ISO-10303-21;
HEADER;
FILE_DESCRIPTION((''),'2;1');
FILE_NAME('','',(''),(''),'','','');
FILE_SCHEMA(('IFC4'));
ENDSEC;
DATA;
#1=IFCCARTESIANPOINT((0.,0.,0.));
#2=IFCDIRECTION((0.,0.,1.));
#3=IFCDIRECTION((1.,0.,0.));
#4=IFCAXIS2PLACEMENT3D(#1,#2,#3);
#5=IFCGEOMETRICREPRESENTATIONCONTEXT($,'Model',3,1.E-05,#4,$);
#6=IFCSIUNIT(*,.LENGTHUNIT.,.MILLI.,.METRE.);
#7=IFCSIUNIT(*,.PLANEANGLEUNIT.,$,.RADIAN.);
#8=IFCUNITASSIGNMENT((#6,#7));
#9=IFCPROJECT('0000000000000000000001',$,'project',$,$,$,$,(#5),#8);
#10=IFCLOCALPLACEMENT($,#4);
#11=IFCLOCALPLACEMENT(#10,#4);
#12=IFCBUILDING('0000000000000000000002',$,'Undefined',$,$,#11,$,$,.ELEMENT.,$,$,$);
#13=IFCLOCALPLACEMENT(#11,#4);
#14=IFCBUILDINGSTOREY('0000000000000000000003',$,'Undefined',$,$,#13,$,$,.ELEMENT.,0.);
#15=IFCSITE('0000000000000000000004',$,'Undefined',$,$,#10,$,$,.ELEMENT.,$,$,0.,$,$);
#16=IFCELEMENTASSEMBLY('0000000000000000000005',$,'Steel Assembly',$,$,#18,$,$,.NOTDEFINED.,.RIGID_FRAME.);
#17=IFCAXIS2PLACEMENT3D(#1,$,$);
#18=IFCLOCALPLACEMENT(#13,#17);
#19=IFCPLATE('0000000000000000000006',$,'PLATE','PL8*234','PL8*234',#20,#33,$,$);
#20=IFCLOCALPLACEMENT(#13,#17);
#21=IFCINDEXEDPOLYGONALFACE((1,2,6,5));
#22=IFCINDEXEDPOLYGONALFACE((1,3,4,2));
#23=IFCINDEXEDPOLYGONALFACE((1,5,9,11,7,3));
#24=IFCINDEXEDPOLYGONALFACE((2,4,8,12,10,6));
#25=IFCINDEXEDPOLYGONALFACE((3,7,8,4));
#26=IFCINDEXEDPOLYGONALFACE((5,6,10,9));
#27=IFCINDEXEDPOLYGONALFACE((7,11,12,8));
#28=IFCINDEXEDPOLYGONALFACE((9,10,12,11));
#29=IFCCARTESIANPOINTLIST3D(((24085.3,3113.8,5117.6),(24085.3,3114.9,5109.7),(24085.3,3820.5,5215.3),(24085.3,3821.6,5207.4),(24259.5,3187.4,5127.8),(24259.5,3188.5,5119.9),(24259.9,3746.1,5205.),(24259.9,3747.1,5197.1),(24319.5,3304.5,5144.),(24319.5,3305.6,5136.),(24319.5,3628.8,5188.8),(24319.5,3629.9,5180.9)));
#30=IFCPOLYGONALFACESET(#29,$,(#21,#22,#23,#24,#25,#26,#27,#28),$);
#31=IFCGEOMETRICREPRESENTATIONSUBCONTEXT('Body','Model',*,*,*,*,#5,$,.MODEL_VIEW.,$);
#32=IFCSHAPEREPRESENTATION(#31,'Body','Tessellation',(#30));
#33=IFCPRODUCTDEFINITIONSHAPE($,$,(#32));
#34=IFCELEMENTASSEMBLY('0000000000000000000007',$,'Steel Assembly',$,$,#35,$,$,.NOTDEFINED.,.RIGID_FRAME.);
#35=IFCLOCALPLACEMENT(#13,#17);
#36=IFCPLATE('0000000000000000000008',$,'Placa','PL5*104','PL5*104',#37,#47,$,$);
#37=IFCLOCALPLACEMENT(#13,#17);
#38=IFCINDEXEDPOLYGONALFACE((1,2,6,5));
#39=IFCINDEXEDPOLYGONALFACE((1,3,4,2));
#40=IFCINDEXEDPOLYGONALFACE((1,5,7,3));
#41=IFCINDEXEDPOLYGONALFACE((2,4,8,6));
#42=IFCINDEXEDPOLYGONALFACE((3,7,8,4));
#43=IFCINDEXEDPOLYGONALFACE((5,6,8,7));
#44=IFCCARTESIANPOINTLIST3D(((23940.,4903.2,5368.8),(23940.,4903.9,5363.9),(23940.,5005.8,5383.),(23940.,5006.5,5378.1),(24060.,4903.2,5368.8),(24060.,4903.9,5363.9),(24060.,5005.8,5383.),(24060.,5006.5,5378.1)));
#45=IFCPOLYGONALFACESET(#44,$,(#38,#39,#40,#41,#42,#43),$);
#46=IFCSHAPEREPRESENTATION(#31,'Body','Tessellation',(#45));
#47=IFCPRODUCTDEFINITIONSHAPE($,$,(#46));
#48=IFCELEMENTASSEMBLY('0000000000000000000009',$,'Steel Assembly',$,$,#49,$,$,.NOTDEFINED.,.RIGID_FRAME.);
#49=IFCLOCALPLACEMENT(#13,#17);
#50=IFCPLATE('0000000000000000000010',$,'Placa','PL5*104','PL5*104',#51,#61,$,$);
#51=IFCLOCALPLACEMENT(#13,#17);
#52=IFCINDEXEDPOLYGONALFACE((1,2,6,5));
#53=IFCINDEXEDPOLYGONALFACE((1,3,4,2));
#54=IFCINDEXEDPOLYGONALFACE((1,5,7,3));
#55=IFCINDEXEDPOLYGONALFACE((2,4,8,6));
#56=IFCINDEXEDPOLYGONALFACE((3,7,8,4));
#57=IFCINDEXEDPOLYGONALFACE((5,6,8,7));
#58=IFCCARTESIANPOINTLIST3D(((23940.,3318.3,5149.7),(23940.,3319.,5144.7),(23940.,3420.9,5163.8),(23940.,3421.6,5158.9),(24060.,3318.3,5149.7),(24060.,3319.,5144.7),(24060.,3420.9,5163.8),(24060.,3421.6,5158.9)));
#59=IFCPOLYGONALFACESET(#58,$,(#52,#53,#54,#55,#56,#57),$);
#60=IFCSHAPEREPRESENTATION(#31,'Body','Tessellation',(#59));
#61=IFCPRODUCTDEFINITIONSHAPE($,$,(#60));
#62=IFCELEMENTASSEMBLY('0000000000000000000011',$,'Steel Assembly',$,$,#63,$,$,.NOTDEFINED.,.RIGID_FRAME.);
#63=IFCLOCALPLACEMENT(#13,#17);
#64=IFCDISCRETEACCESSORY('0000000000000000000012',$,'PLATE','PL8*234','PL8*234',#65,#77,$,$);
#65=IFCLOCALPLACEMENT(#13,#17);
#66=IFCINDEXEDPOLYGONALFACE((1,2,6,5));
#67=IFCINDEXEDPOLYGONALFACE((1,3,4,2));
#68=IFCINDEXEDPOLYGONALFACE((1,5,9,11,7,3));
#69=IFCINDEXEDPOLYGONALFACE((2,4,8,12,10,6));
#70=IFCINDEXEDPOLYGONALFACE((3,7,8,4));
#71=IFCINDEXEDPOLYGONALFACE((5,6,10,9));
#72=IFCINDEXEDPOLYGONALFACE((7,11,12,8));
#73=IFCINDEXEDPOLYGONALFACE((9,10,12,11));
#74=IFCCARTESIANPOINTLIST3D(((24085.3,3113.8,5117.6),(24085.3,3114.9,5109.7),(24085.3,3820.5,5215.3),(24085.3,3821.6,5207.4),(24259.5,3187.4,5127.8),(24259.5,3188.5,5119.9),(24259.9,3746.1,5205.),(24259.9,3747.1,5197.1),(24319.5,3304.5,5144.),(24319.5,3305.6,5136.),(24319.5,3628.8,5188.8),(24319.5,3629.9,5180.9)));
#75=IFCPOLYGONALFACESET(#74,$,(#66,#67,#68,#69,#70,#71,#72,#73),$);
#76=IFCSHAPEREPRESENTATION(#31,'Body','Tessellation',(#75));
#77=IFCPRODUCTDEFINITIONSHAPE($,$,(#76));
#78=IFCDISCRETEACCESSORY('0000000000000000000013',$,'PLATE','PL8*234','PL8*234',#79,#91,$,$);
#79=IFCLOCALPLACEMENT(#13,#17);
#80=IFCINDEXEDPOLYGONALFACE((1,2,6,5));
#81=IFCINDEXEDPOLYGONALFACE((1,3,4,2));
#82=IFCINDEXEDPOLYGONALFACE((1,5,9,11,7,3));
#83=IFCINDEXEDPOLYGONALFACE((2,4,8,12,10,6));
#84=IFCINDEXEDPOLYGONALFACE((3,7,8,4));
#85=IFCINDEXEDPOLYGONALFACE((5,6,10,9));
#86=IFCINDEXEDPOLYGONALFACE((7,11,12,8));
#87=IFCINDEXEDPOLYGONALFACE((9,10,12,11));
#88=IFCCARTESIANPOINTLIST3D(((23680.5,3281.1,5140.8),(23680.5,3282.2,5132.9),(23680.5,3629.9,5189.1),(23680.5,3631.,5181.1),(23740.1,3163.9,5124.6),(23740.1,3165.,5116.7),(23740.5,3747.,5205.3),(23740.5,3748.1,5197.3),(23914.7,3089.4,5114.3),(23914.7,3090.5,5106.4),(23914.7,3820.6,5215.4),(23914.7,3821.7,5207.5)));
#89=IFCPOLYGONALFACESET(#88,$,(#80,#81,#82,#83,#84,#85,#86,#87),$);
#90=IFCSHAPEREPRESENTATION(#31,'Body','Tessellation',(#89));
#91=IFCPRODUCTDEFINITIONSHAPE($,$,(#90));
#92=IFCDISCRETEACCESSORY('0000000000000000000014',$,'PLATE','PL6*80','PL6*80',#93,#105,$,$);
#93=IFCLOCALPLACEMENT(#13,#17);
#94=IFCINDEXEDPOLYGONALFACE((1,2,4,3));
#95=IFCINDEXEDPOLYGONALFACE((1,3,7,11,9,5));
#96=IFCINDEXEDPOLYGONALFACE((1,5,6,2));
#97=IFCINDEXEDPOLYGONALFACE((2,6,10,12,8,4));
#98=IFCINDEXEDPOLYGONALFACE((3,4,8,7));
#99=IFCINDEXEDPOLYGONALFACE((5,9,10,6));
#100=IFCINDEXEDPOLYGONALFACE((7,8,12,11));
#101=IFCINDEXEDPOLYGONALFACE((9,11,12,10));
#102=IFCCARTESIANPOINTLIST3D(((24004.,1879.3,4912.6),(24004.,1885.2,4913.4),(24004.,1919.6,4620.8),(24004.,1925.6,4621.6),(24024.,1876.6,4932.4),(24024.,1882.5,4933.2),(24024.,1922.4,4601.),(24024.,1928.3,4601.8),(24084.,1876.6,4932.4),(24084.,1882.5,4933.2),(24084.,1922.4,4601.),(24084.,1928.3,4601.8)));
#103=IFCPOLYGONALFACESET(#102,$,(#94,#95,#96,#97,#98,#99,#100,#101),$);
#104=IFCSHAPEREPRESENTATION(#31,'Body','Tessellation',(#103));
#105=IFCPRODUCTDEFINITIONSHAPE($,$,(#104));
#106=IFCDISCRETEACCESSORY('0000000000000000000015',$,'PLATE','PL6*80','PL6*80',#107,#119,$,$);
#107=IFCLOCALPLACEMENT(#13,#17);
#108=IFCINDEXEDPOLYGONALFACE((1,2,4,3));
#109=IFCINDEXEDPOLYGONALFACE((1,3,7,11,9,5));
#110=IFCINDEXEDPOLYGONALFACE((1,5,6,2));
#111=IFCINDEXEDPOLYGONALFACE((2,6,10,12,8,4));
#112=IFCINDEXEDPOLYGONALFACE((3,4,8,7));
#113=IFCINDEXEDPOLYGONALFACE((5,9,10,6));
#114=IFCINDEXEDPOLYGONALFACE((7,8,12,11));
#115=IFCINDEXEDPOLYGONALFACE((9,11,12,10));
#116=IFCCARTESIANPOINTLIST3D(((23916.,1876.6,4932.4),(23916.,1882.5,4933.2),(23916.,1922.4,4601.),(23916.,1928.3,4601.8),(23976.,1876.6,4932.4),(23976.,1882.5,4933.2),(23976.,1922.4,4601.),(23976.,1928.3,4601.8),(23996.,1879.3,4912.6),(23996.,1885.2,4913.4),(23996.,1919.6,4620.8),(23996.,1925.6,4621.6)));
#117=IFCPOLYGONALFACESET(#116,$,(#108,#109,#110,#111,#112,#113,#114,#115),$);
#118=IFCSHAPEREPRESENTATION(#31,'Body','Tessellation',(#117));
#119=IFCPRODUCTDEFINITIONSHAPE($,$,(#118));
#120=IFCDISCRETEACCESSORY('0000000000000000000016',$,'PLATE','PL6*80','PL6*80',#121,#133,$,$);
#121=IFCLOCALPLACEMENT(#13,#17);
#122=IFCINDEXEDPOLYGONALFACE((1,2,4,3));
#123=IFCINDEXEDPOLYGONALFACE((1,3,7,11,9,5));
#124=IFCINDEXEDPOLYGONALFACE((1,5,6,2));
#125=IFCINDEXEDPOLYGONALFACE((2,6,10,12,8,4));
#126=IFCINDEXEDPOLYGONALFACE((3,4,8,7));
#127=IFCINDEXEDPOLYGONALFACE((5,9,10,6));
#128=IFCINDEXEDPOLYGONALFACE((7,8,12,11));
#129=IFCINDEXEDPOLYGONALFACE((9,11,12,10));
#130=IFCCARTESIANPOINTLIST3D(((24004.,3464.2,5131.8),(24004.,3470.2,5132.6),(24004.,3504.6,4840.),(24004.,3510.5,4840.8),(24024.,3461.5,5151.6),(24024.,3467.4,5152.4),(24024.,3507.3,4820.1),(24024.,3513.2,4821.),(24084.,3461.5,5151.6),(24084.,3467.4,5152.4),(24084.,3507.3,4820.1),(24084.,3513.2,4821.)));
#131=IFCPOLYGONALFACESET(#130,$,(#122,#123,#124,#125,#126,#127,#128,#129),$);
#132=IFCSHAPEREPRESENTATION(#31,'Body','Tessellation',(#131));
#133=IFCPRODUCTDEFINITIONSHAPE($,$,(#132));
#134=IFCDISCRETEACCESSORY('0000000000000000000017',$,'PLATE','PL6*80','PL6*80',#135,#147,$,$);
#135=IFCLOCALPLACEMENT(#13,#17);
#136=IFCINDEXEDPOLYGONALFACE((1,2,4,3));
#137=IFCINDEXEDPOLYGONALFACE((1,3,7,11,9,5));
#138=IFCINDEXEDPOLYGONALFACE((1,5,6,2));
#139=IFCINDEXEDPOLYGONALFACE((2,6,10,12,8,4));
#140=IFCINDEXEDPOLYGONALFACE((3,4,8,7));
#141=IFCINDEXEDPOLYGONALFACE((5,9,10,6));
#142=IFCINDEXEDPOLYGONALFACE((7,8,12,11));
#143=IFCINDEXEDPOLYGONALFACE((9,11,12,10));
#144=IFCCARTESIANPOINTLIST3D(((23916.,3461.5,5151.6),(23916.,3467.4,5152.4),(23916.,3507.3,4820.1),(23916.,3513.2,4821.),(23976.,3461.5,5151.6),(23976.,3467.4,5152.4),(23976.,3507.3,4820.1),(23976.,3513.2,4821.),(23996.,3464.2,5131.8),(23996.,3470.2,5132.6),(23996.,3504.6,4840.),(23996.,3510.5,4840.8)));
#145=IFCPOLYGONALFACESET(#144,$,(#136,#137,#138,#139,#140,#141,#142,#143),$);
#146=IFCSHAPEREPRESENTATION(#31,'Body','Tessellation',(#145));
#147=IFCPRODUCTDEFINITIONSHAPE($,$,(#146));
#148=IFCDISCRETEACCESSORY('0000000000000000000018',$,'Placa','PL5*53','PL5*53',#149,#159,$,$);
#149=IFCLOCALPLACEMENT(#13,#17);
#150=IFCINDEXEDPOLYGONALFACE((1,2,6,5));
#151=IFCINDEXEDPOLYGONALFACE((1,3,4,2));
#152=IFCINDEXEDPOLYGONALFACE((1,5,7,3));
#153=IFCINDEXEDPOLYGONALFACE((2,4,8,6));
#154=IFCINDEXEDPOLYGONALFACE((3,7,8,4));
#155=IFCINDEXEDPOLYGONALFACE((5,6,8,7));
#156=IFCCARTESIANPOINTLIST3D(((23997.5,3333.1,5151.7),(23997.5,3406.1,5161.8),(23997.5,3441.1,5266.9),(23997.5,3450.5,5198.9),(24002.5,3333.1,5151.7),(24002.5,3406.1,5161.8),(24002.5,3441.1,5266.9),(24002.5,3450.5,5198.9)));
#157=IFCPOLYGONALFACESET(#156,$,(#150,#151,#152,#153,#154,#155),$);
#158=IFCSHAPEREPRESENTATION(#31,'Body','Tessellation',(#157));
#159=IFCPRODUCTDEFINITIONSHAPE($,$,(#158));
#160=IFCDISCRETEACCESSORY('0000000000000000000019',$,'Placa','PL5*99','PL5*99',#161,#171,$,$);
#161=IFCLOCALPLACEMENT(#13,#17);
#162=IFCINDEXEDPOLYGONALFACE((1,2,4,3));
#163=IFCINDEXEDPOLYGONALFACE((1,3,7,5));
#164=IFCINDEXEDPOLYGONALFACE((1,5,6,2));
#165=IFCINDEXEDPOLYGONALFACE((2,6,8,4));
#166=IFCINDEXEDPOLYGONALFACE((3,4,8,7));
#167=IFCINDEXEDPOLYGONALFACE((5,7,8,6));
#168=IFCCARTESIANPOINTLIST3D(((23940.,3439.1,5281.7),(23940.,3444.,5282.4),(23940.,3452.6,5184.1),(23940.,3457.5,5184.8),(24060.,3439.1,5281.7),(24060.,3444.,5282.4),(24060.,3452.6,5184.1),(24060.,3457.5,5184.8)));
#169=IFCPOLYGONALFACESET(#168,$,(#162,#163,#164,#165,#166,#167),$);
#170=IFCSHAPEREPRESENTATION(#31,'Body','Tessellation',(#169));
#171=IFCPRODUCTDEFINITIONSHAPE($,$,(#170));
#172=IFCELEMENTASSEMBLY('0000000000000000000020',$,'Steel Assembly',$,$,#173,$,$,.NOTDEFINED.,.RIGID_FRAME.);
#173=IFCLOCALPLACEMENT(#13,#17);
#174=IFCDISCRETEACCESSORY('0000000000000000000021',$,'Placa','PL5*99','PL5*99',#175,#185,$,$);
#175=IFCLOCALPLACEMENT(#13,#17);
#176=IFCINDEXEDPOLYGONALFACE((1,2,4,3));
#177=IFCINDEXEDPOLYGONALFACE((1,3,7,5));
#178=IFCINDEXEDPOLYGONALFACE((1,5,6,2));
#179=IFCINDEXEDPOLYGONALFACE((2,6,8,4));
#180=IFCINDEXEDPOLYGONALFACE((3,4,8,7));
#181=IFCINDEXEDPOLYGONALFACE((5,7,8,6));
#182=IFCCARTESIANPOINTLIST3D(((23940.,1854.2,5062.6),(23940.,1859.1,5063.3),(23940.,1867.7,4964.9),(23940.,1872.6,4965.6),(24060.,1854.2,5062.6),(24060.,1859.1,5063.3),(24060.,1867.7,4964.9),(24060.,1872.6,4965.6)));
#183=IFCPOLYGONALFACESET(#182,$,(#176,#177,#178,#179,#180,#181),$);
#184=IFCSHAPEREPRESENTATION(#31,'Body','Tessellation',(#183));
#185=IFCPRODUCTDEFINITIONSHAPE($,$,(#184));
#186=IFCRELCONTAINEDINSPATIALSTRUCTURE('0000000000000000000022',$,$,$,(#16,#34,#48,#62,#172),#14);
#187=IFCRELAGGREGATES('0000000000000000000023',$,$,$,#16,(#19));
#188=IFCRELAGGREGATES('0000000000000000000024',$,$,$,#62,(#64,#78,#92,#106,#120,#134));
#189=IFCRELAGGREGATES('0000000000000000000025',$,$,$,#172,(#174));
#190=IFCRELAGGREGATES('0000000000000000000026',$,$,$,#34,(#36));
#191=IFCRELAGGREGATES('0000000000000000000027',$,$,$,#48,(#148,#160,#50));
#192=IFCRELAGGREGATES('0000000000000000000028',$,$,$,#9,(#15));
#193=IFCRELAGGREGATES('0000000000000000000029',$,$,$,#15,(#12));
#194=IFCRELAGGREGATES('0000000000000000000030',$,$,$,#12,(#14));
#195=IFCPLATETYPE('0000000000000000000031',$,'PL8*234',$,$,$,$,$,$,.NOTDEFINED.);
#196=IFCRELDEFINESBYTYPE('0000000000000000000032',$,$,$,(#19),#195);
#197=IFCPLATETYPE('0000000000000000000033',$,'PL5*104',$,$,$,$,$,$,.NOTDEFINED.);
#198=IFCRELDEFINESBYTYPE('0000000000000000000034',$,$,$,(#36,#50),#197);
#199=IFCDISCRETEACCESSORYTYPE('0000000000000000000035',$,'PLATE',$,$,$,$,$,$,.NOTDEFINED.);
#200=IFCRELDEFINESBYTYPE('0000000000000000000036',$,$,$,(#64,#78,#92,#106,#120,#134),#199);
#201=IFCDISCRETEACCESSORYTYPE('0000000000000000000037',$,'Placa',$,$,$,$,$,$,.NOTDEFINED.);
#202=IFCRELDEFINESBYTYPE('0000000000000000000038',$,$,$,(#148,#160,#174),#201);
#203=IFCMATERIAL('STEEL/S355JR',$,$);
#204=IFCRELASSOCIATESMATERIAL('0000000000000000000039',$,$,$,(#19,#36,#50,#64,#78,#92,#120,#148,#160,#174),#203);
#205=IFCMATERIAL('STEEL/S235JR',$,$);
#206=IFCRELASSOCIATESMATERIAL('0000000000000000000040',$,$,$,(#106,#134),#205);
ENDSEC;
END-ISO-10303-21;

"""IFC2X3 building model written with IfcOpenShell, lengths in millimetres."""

from ifc_helpers import new_model, si_unit, frame, origin_with_axes, place, context, subcontext, project, spatial, polyline, outline, extrude, material, type_object, element, aggregate, save


model = new_model("IFC2X3")

# Units and contexts
model_context = context("Model", 3, precision=1e-05, world=origin_with_axes())
body_context = subcontext(model_context, "Body", "Model", "MODEL_VIEW")
ifc_project = project(units=[si_unit("LENGTHUNIT", "METRE", prefix="MILLI"), si_unit("PLANEANGLEUNIT", "RADIAN")], contexts=[model_context])

# Site, building, storey
site_placement = place(None, origin_with_axes())
site = spatial("IfcSite", under=ifc_project, at=site_placement, Name="Undefined", CompositionType="ELEMENT", RefElevation=0.0)
building_placement = place(site_placement, origin_with_axes())
building = spatial("IfcBuilding", under=site, at=building_placement, Name="Undefined", CompositionType="ELEMENT")
storey_placement = place(building_placement, origin_with_axes())
storey = spatial("IfcBuildingStorey", under=building, at=storey_placement, Name="Undefined", CompositionType="ELEMENT", Elevation=0.0)

# Shared definitions
ifc_material_1 = material(Name="STEEL/S355JR")

# Element assemblies, plates
assembly_1_placement = place(storey_placement, origin_with_axes())
assembly_1 = element("IfcElementAssembly", 1, at=assembly_1_placement, inside=storey, Name="Steel Assembly", AssemblyPlace="NOTDEFINED", PredefinedType="RIGID_FRAME")
plate_type_1 = type_object("IfcPlateType", Name="PL8*234", PredefinedType="NOTDEFINED")
plate_1_placement = place(assembly_1_placement, frame((24085.3, 3821.1, 5211.4), z_axis=(-0.000018, -0.13698, 0.990574), x_axis=(0.0, -0.990574, -0.13698)))
plate_1 = element("IfcPlate", 2, at=plate_1_placement, type_object=plate_type_1, material=ifc_material_1, Name="PLATE", Description="PL8*234", ObjectType="PL8*234", context=body_context, shape_type="SweptSolid", body=[
    extrude(outline(polyline([(0.0, 0.0), (713.5, 0.0), (639.1, 174.2), (520.9, 234.3), (193.6, 234.3), (75.2, 174.6), (0.0, 0.0)])), frame((0.0, 0.0, -4.0), z_axis=(0.0, 0.0, 1.0), x_axis=(1.0, 0.0, 0.0)), (0.0, 0.0, 1.0), 8.0),
])
aggregate(assembly_1, [plate_1])
assembly_2_placement = place(storey_placement, origin_with_axes())
assembly_2 = element("IfcElementAssembly", 3, at=assembly_2_placement, inside=storey, Name="Steel Assembly", AssemblyPlace="NOTDEFINED", PredefinedType="RIGID_FRAME")
plate_type_2 = type_object("IfcPlateType", Name="PL5*104", PredefinedType="NOTDEFINED")
plate_2_placement = place(assembly_2_placement, frame((23940.0, 5006.2, 5380.5), z_axis=(0.0, -0.136905, 0.990584), x_axis=(0.0, -0.990584, -0.136905)))
plate_2 = element("IfcPlate", 4, at=plate_2_placement, type_object=plate_type_2, material=ifc_material_1, Name="Placa", Description="PL5*104", ObjectType="PL5*104", context=body_context, shape_type="SweptSolid", body=[
    extrude(outline(polyline([(0.0, 0.0), (103.6, 0.0), (103.6, 120.0), (0.0, 120.0), (0.0, 0.0)])), frame((0.0, 0.0, -2.5), z_axis=(0.0, 0.0, 1.0), x_axis=(1.0, 0.0, 0.0)), (0.0, 0.0, 1.0), 5.0),
])
assembly_3_placement = place(storey_placement, origin_with_axes())
assembly_3 = element("IfcElementAssembly", 5, at=assembly_3_placement, inside=storey, Name="Steel Assembly", AssemblyPlace="NOTDEFINED", PredefinedType="RIGID_FRAME")
plate_3_placement = place(assembly_3_placement, frame((23940.0, 3421.3, 5161.4), z_axis=(0.0, -0.136905, 0.990584), x_axis=(0.0, -0.990584, -0.136905)))
plate_3 = element("IfcPlate", 6, at=plate_3_placement, type_object=plate_type_2, material=ifc_material_1, Name="Placa", Description="PL5*104", ObjectType="PL5*104", context=body_context, shape_type="SweptSolid", body=[
    extrude(outline(polyline([(0.0, 0.0), (103.6, 0.0), (103.6, 120.0), (0.0, 120.0), (0.0, 0.0)])), frame((0.0, 0.0, -2.5), z_axis=(0.0, 0.0, 1.0), x_axis=(1.0, 0.0, 0.0)), (0.0, 0.0, 1.0), 5.0),
])

# Element assembly, discrete accessories
assembly_4_placement = place(storey_placement, origin_with_axes())
assembly_4 = element("IfcElementAssembly", 7, at=assembly_4_placement, inside=storey, Name="Steel Assembly", AssemblyPlace="NOTDEFINED", PredefinedType="RIGID_FRAME")
discrete_accessory_type_1 = type_object("IfcDiscreteAccessoryType", Name="PLATE")
discrete_accessory_1_placement = place(assembly_4_placement, frame((24085.3, 3821.1, 5211.4), z_axis=(-0.000018, -0.13698, 0.990574), x_axis=(0.0, -0.990574, -0.13698)))
discrete_accessory_1 = element("IfcDiscreteAccessory", 8, at=discrete_accessory_1_placement, type_object=discrete_accessory_type_1, material=ifc_material_1, Name="PLATE", Description="PL8*234", ObjectType="PL8*234", context=body_context, shape_type="SweptSolid", body=[
    extrude(outline(polyline([(0.0, 0.0), (713.5, 0.0), (639.1, 174.2), (520.9, 234.3), (193.6, 234.3), (75.2, 174.6), (0.0, 0.0)])), frame((0.0, 0.0, -4.0), z_axis=(0.0, 0.0, 1.0), x_axis=(1.0, 0.0, 0.0)), (0.0, 0.0, 1.0), 8.0),
])
discrete_accessory_2_placement = place(assembly_4_placement, frame((23914.7, 3089.9, 5110.4), z_axis=(-0.000018, -0.13698, 0.990574), x_axis=(0.0, 0.990574, 0.13698)))
discrete_accessory_2 = element("IfcDiscreteAccessory", 9, at=discrete_accessory_2_placement, type_object=discrete_accessory_type_1, material=ifc_material_1, Name="PLATE", Description="PL8*234", ObjectType="PL8*234", context=body_context, shape_type="SweptSolid", body=[
    extrude(outline(polyline([(0.0, 0.0), (738.2, 0.0), (663.9, 174.2), (545.6, 234.3), (193.6, 234.3), (75.2, 174.6), (0.0, 0.0)])), frame((0.0, 0.0, -4.0), z_axis=(0.0, 0.0, 1.0), x_axis=(1.0, 0.0, 0.0)), (0.0, 0.0, 1.0), 8.0),
])
discrete_accessory_3_placement = place(assembly_4_placement, frame((24084.0, 1925.4, 4601.4), z_axis=(0.0, 0.990574, 0.13698), x_axis=(-1.0, 0.0, 0.0)))
discrete_accessory_3 = element("IfcDiscreteAccessory", 10, at=discrete_accessory_3_placement, type_object=discrete_accessory_type_1, material=ifc_material_1, Name="PLATE", Description="PL6*80", ObjectType="PL6*80", context=body_context, shape_type="SweptSolid", body=[
    extrude(outline(polyline([(0.0, 0.0), (60.0, 0.0), (80.0, 20.0), (80.0, 314.6), (60.0, 334.6), (0.0, 334.6), (0.0, 0.0)])), frame((0.0, 0.0, -3.0), z_axis=(0.0, 0.0, 1.0), x_axis=(1.0, 0.0, 0.0)), (0.0, 0.0, 1.0), 6.0),
])
ifc_material_2 = material(Name="STEEL/S235JR")
discrete_accessory_4_placement = place(assembly_4_placement, frame((23996.0, 1925.4, 4601.4), z_axis=(0.0, 0.990574, 0.13698), x_axis=(-1.0, 0.0, 0.0)))
discrete_accessory_4 = element("IfcDiscreteAccessory", 11, at=discrete_accessory_4_placement, type_object=discrete_accessory_type_1, material=ifc_material_2, Name="PLATE", Description="PL6*80", ObjectType="PL6*80", context=body_context, shape_type="SweptSolid", body=[
    extrude(outline(polyline([(0.0, 20.0), (20.0, 0.0), (80.0, 0.0), (80.0, 334.6), (20.0, 334.6), (0.0, 314.6), (0.0, 20.0)])), frame((0.0, 0.0, -3.0), z_axis=(0.0, 0.0, 1.0), x_axis=(1.0, 0.0, 0.0)), (0.0, 0.0, 1.0), 6.0),
])
discrete_accessory_5_placement = place(assembly_4_placement, frame((24084.0, 3510.3, 4820.6), z_axis=(0.0, 0.990574, 0.13698), x_axis=(-1.0, 0.0, 0.0)))
discrete_accessory_5 = element("IfcDiscreteAccessory", 12, at=discrete_accessory_5_placement, type_object=discrete_accessory_type_1, material=ifc_material_1, Name="PLATE", Description="PL6*80", ObjectType="PL6*80", context=body_context, shape_type="SweptSolid", body=[
    extrude(outline(polyline([(0.0, 0.0), (60.0, 0.0), (80.0, 20.0), (80.0, 314.6), (60.0, 334.6), (0.0, 334.6), (0.0, 0.0)])), frame((0.0, 0.0, -3.0), z_axis=(0.0, 0.0, 1.0), x_axis=(1.0, 0.0, 0.0)), (0.0, 0.0, 1.0), 6.0),
])
discrete_accessory_6_placement = place(assembly_4_placement, frame((23996.0, 3510.3, 4820.6), z_axis=(0.0, 0.990574, 0.13698), x_axis=(-1.0, 0.0, 0.0)))
discrete_accessory_6 = element("IfcDiscreteAccessory", 13, at=discrete_accessory_6_placement, type_object=discrete_accessory_type_1, material=ifc_material_2, Name="PLATE", Description="PL6*80", ObjectType="PL6*80", context=body_context, shape_type="SweptSolid", body=[
    extrude(outline(polyline([(0.0, 20.0), (20.0, 0.0), (80.0, 0.0), (80.0, 334.6), (20.0, 334.6), (0.0, 314.6), (0.0, 20.0)])), frame((0.0, 0.0, -3.0), z_axis=(0.0, 0.0, 1.0), x_axis=(1.0, 0.0, 0.0)), (0.0, 0.0, 1.0), 6.0),
])
aggregate(assembly_4, [discrete_accessory_1, discrete_accessory_2, discrete_accessory_3, discrete_accessory_4, discrete_accessory_5, discrete_accessory_6])

# Discrete accessories
discrete_accessory_type_2 = type_object("IfcDiscreteAccessoryType", Name="Placa")
discrete_accessory_7_placement = place(assembly_3_placement, frame((24000.0, 3441.1, 5266.9), z_axis=(1.0, 0.0, 0.0), x_axis=(0.0, -0.684057, -0.729429)))
discrete_accessory_7 = element("IfcDiscreteAccessory", 14, at=discrete_accessory_7_placement, type_object=discrete_accessory_type_2, material=ifc_material_1, Name="Placa", Description="PL5*53", ObjectType="PL5*53", context=body_context, shape_type="SweptSolid", body=[
    extrude(outline(polyline([(0.0, 0.0), (157.9, 0.0), (100.7, 46.3), (43.1, 53.3), (0.0, 0.0)])), frame((0.0, 0.0, -2.5), z_axis=(0.0, 0.0, 1.0), x_axis=(1.0, 0.0, 0.0)), (0.0, 0.0, 1.0), 5.0),
])
discrete_accessory_8_placement = place(assembly_3_placement, frame((23940.0, 3455.1, 5184.4), z_axis=(0.0, 0.990592, 0.136849), x_axis=(0.0, -0.136849, 0.990592)))
discrete_accessory_8 = element("IfcDiscreteAccessory", 15, at=discrete_accessory_8_placement, type_object=discrete_accessory_type_2, material=ifc_material_1, Name="Placa", Description="PL5*99", ObjectType="PL5*99", context=body_context, shape_type="SweptSolid", body=[
    extrude(outline(polyline([(0.0, 0.0), (98.6, 0.0), (98.6, 120.0), (0.0, 120.0), (0.0, 0.0)])), frame((0.0, 0.0, -2.5), z_axis=(0.0, 0.0, 1.0), x_axis=(1.0, 0.0, 0.0)), (0.0, 0.0, 1.0), 5.0),
])

# Element assembly, discrete accessory
assembly_5_placement = place(storey_placement, origin_with_axes())
assembly_5 = element("IfcElementAssembly", 16, at=assembly_5_placement, inside=storey, Name="Steel Assembly", AssemblyPlace="NOTDEFINED", PredefinedType="RIGID_FRAME")
discrete_accessory_9_placement = place(assembly_5_placement, frame((23940.0, 1870.1, 4965.2), z_axis=(0.0, 0.990592, 0.136849), x_axis=(0.0, -0.136849, 0.990592)))
discrete_accessory_9 = element("IfcDiscreteAccessory", 17, at=discrete_accessory_9_placement, type_object=discrete_accessory_type_2, material=ifc_material_1, Name="Placa", Description="PL5*99", ObjectType="PL5*99", context=body_context, shape_type="SweptSolid", body=[
    extrude(outline(polyline([(0.0, 0.0), (98.6, 0.0), (98.6, 120.0), (0.0, 120.0), (0.0, 0.0)])), frame((0.0, 0.0, -2.5), z_axis=(0.0, 0.0, 1.0), x_axis=(1.0, 0.0, 0.0)), (0.0, 0.0, 1.0), 5.0),
])

aggregate(assembly_5, [discrete_accessory_9])
aggregate(assembly_2, [plate_2])
aggregate(assembly_3, [discrete_accessory_7, discrete_accessory_8, plate_3])

save(model, "model.ifc")
